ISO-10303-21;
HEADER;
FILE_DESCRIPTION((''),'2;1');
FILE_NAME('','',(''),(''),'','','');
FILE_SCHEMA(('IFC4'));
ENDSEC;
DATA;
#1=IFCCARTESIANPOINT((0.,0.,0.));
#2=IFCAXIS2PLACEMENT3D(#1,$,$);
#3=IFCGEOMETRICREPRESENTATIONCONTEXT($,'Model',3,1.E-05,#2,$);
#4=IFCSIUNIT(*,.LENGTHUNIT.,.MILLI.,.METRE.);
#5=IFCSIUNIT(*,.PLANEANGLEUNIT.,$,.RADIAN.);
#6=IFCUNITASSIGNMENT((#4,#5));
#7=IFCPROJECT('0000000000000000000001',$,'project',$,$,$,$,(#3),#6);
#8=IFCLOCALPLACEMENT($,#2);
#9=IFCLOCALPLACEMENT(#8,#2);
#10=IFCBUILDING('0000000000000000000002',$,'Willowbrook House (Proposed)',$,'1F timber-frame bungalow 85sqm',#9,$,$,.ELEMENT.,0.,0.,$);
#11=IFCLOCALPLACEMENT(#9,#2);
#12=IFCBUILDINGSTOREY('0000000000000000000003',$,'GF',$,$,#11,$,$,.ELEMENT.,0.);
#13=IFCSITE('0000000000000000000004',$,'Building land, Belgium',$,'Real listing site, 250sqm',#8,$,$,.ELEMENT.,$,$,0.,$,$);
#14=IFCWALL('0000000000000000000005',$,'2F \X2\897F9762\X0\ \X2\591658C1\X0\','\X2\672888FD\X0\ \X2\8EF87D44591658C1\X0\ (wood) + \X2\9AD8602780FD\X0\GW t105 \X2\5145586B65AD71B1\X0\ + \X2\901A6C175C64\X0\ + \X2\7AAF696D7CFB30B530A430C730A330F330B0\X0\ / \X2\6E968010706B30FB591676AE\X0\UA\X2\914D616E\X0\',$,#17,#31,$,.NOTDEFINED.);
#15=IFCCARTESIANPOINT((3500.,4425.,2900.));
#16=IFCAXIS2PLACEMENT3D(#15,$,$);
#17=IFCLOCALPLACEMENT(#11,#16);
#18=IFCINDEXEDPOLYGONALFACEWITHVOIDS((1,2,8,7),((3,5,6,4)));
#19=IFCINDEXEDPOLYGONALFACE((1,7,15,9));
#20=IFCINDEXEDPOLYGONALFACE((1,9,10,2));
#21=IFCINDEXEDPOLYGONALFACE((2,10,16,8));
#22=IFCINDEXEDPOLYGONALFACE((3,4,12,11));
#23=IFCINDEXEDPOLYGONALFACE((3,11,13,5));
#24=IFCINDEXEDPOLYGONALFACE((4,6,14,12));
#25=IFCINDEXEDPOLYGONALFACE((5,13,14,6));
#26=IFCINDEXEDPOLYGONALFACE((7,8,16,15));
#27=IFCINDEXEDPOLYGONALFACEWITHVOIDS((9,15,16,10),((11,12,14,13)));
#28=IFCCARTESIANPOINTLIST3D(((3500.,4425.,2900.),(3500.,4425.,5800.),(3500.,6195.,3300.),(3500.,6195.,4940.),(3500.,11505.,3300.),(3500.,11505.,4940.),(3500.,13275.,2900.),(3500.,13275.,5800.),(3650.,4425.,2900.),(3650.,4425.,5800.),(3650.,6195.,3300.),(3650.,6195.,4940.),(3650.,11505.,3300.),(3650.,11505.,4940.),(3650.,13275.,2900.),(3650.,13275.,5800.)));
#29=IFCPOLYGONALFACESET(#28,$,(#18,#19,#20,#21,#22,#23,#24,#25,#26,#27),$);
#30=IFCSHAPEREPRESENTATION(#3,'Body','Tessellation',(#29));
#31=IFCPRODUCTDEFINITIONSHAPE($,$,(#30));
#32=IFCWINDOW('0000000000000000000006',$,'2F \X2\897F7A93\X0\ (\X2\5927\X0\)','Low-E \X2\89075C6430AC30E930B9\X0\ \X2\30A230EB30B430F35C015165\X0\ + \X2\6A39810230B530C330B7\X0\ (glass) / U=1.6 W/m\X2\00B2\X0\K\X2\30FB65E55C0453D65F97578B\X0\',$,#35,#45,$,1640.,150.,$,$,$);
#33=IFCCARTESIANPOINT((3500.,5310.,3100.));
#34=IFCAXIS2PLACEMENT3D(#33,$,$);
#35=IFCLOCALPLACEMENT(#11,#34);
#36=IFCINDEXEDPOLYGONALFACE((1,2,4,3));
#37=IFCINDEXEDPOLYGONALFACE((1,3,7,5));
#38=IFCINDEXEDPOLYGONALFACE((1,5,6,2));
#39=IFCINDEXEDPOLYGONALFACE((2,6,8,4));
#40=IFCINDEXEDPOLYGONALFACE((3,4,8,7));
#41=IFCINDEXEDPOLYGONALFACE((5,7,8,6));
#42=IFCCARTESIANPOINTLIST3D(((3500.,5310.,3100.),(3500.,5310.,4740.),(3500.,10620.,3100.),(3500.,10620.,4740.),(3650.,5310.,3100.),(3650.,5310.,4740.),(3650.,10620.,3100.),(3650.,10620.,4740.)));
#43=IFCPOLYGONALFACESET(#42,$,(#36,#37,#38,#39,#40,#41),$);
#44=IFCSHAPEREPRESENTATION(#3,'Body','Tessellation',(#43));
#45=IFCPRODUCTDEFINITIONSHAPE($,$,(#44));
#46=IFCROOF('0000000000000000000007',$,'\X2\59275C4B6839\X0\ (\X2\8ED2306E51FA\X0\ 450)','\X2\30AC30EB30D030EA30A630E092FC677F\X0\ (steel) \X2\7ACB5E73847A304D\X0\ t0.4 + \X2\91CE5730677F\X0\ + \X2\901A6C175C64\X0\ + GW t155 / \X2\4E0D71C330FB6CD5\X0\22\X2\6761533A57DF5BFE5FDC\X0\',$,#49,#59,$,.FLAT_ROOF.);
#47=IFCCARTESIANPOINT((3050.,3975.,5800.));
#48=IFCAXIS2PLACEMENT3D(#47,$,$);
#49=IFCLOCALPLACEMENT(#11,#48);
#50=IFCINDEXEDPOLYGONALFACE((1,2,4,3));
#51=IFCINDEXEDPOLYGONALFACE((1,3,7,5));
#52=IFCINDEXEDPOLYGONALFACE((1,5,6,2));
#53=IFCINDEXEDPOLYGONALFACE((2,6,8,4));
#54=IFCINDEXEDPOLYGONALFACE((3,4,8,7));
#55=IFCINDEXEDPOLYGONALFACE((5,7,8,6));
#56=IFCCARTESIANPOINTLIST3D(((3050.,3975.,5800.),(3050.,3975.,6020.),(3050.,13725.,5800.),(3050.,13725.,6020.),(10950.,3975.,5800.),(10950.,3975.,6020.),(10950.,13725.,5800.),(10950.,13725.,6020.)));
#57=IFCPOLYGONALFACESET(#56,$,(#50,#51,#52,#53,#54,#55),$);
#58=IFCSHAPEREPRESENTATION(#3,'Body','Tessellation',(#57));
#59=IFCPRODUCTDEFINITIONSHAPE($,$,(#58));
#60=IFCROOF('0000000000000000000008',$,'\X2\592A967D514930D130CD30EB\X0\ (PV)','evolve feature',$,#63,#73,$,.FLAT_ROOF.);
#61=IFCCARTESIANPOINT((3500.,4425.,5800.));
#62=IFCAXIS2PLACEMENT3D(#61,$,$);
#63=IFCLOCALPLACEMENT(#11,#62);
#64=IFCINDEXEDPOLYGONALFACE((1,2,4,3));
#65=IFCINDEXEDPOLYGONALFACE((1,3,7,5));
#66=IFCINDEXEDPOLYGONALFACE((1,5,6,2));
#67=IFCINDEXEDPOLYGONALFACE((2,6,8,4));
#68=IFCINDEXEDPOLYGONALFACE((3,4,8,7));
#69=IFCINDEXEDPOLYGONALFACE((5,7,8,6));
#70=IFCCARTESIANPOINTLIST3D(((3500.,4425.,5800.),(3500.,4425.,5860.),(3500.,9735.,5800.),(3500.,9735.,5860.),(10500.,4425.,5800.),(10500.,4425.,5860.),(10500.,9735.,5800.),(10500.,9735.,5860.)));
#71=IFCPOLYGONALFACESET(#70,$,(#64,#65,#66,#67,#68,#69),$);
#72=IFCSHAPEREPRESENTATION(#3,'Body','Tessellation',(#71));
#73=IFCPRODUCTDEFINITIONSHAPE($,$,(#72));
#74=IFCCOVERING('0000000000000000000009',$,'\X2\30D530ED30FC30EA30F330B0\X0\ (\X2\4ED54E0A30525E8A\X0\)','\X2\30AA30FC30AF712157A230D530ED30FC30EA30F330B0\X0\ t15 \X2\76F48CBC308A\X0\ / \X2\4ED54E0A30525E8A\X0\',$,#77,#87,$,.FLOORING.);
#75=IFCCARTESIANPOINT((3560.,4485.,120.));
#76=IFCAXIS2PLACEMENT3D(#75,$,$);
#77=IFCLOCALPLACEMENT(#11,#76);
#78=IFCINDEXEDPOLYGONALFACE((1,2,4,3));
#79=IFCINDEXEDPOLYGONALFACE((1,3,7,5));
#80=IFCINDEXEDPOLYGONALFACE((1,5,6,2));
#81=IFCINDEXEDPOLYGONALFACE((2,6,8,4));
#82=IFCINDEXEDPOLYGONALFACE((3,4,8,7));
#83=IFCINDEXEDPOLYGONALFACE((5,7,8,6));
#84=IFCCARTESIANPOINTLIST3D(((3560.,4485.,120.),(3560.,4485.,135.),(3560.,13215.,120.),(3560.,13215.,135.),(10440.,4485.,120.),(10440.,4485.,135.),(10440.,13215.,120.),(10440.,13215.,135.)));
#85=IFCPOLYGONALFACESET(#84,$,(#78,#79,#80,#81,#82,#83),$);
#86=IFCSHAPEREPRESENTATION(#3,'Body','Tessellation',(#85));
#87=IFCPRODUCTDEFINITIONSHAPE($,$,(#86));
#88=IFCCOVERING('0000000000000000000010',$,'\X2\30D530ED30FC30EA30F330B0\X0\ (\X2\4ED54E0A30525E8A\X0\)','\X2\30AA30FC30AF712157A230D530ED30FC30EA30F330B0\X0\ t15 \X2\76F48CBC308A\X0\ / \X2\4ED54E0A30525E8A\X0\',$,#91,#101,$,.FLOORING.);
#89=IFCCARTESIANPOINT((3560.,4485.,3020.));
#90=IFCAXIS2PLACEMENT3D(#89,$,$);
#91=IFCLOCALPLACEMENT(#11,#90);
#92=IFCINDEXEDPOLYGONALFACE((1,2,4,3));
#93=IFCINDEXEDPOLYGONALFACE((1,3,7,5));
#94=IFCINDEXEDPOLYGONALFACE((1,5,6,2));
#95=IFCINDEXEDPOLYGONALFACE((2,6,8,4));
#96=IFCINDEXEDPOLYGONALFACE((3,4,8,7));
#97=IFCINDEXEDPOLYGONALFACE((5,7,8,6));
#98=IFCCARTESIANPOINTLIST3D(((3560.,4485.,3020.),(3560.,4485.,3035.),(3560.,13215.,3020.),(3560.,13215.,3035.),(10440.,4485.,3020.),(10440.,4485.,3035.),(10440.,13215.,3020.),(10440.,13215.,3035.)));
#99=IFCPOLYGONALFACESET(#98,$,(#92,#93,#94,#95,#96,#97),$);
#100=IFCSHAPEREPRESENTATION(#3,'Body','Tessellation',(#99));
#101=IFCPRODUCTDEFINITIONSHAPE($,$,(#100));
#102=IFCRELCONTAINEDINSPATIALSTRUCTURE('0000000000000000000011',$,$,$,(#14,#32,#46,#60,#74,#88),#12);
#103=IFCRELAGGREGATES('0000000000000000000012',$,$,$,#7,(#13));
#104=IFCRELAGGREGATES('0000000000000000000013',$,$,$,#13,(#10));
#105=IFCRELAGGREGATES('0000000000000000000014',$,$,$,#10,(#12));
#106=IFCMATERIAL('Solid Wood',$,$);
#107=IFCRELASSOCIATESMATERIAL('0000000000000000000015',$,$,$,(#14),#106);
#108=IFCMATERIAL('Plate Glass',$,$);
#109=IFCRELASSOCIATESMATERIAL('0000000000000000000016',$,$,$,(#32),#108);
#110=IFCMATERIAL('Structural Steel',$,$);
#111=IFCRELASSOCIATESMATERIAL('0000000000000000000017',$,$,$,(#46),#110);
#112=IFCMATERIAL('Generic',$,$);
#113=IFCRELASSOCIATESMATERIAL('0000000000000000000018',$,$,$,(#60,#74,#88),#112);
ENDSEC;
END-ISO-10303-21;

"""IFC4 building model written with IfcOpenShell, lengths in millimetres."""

from ifc_helpers import new_model, si_unit, frame, frame_2d, origin, place, context, project, spatial, rectangle, extrude, material, element, fill, save


model = new_model("IFC4")

# Units and contexts
model_context = context("Model", 3, precision=1e-05, world=origin())
ifc_project = project(units=[si_unit("LENGTHUNIT", "METRE", prefix="MILLI"), si_unit("PLANEANGLEUNIT", "RADIAN")], contexts=[model_context])

# Site, building, storey
site_placement = place(None, origin())
site = spatial("IfcSite", under=ifc_project, at=site_placement, Name="Building land, Belgium", ObjectType="Real listing site, 250sqm", CompositionType="ELEMENT", RefElevation=0.0)
building_placement = place(site_placement, origin())
building = spatial("IfcBuilding", under=site, at=building_placement, Name="Willowbrook House (Proposed)", ObjectType="1F timber-frame bungalow 85sqm", CompositionType="ELEMENT", ElevationOfRefHeight=0.0, ElevationOfTerrain=0.0)
storey_placement = place(building_placement, origin())
storey = spatial("IfcBuildingStorey", under=building, at=storey_placement, Name="GF", CompositionType="ELEMENT", Elevation=0.0)

# Shared definitions
ifc_material_1 = material(Name="Solid Wood")
ifc_material_2 = material(Name="Generic")

# Shared definitions
ifc_material_3 = material(Name="Plate Glass")

# Wall, opening, window
wall_1_placement = place(storey_placement, frame((3500.0, 4425.0, 2900.0)))
wall_1 = element("IfcWall", 1, at=wall_1_placement, inside=storey, material=ifc_material_1, Name="2F 西面 外壁", Description="木製 軸組外壁 (wood) + 高性能GW t105 充填断熱 + 通気層 + 窯業系サイディング / 準耐火・外皮UA配慮", PredefinedType="NOTDEFINED", context=model_context, shape_type="SweptSolid", body=[
    extrude(rectangle(XDim=150.0, YDim=8850.0, at=frame_2d((75.0, 4425.0))), frame((3500.0, 4425.0, 2900.0)), (0.0, 0.0, 1.0), 2900.0),
])
opening_1_placement = place(storey_placement, frame((3500.0, 5310.0, 3100.0)))
opening_1 = element("IfcOpeningElement", 2, at=opening_1_placement, cuts=wall_1, PredefinedType="NOTDEFINED", context=model_context, shape_type="SweptSolid", body=[
    extrude(rectangle(XDim=150.0, YDim=5310.0, at=frame_2d((75.0, 2655.0))), frame((3500.0, 5310.0, 3100.0)), (0.0, 0.0, 1.0), 1640.0),
])
window_1_placement = place(storey_placement, frame((3500.0, 5310.0, 3100.0)))
window_1 = element("IfcWindow", 3, at=window_1_placement, inside=storey, material=ifc_material_3, Name="2F 西窓 (大)", Description="Low-E 複層ガラス アルゴン封入 + 樹脂サッシ (glass) / U=1.6 W/m²K・日射取得型", OverallHeight=1640.0, OverallWidth=150.0, context=model_context, shape_type="SweptSolid", body=[
    extrude(rectangle(XDim=150.0, YDim=5310.0, at=frame_2d((75.0, 2655.0))), frame((3500.0, 5310.0, 3100.0)), (0.0, 0.0, 1.0), 1640.0),
])
fill(opening_1, window_1)

# Roofs
ifc_material_4 = material(Name="Structural Steel")
roof_1_placement = place(storey_placement, frame((3050.0, 3975.0, 5800.0)))
element("IfcRoof", 4, at=roof_1_placement, inside=storey, material=ifc_material_4, Name="大屋根 (軒の出 450)", Description="ガルバリウム鋼板 (steel) 立平葺き t0.4 + 野地板 + 通気層 + GW t155 / 不燃・法22条区域対応", PredefinedType="FLAT_ROOF", context=model_context, shape_type="SweptSolid", body=[
    extrude(rectangle(XDim=7900.0, YDim=9750.0, at=frame_2d((3950.0, 4875.0))), frame((3050.0, 3975.0, 5800.0)), (0.0, 0.0, 1.0), 220.0),
])
roof_2_placement = place(storey_placement, frame((3500.0, 4425.0, 5800.0)))
element("IfcRoof", 5, at=roof_2_placement, inside=storey, material=ifc_material_2, Name="太陽光パネル (PV)", Description="evolve feature", PredefinedType="FLAT_ROOF", context=model_context, shape_type="SweptSolid", body=[
    extrude(rectangle(XDim=7000.0, YDim=5310.0, at=frame_2d((3500.0, 2655.0))), frame((3500.0, 4425.0, 5800.0)), (0.0, 0.0, 1.0), 60.0),
])

# Coverings
covering_1_placement = place(storey_placement, frame((3560.0, 4485.0, 120.0)))
element("IfcCovering", 6, at=covering_1_placement, inside=storey, material=ifc_material_2, Name="フローリング (仕上げ床)", Description="オーク無垢フローリング t15 直貼り / 仕上げ床", PredefinedType="FLOORING", context=model_context, shape_type="SweptSolid", body=[
    extrude(rectangle(XDim=6880.0, YDim=8730.0, at=frame_2d((3440.0, 4365.0))), frame((3560.0, 4485.0, 120.0)), (0.0, 0.0, 1.0), 15.0),
])
covering_2_placement = place(storey_placement, frame((3560.0, 4485.0, 3020.0)))
element("IfcCovering", 7, at=covering_2_placement, inside=storey, material=ifc_material_2, Name="フローリング (仕上げ床)", Description="オーク無垢フローリング t15 直貼り / 仕上げ床", PredefinedType="FLOORING", context=model_context, shape_type="SweptSolid", body=[
    extrude(rectangle(XDim=6880.0, YDim=8730.0, at=frame_2d((3440.0, 4365.0))), frame((3560.0, 4485.0, 3020.0)), (0.0, 0.0, 1.0), 15.0),
])

save(model, "model.ifc")
